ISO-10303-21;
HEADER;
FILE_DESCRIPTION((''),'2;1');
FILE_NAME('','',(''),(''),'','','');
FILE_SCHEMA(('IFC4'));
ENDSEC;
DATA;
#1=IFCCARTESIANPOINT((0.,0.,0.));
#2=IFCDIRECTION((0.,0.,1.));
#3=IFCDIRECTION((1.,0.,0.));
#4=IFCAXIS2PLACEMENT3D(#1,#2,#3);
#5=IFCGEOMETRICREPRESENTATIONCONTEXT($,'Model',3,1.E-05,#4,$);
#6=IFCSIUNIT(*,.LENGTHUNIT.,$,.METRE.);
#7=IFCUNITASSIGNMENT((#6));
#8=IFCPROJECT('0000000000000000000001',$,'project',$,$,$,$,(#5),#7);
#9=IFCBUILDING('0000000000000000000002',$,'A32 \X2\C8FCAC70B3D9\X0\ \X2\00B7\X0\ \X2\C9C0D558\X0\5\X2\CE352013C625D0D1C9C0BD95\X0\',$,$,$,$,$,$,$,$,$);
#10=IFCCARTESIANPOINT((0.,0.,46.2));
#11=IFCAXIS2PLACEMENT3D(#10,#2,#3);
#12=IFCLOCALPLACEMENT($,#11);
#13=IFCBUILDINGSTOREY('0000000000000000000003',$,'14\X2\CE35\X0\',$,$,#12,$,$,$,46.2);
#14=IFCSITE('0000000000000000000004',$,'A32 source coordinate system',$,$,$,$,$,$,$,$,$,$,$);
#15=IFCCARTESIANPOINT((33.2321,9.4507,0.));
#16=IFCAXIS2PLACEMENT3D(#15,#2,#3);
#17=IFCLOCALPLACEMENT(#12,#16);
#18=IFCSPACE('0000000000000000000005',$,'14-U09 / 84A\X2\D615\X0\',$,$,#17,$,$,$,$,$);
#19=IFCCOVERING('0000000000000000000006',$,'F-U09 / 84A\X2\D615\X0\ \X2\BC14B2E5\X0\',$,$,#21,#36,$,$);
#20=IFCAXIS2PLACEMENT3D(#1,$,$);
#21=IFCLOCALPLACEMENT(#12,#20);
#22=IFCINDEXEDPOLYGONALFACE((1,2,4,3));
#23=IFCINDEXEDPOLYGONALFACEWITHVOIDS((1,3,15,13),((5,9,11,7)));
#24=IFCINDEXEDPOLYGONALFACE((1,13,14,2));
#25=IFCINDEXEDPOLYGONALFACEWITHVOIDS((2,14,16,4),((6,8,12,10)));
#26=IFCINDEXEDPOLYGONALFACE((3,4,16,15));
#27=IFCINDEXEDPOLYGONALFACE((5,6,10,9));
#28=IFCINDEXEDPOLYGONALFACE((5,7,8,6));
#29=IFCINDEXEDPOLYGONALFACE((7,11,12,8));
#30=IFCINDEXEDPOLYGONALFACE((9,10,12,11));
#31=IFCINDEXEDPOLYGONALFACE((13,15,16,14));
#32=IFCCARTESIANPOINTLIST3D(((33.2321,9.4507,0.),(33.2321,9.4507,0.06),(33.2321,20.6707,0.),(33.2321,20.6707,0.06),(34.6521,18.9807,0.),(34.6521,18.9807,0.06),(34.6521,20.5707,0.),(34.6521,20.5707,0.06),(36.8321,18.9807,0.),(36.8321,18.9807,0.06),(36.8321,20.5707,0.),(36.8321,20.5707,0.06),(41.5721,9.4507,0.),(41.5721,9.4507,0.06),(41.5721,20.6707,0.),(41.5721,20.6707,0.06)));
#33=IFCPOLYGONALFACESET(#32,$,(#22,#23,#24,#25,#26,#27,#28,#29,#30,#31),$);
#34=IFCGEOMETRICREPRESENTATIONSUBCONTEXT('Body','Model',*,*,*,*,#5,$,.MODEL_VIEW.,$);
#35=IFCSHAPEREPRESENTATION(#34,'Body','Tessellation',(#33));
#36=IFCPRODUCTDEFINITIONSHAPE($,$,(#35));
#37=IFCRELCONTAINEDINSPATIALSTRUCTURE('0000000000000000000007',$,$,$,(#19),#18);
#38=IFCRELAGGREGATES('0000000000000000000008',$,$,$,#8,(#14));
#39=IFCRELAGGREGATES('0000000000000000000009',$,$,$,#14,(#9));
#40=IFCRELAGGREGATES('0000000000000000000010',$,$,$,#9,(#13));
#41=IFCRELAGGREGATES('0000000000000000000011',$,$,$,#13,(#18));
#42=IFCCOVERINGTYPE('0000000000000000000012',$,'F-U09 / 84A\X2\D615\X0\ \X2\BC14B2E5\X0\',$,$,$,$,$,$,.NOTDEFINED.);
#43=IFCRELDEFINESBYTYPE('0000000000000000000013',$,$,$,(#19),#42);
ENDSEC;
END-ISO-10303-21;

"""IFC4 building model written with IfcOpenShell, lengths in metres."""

from ifc_helpers import new_model, si_unit, frame, origin, origin_with_axes, place, context, subcontext, project, spatial, polyline, outline, extrude, source, transform, mapped, type_object, type_shapes, element, save


model = new_model("IFC4")

# Units and contexts
model_context = context("Model", 3, precision=1e-05, world=origin_with_axes())
body_context = subcontext(model_context, "Body", "Model", "MODEL_VIEW")
ifc_project = project(units=[si_unit("LENGTHUNIT", "METRE")], contexts=[model_context])

# Site, building, storey, space
storey_placement = place(None, frame((0.0, 0.0, 46.2), z_axis=(0.0, 0.0, 1.0), x_axis=(1.0, 0.0, 0.0)))
space_placement = place(storey_placement, frame((33.2321, 9.4507, 0.0), z_axis=(0.0, 0.0, 1.0), x_axis=(1.0, 0.0, 0.0)))
site = spatial("IfcSite", under=ifc_project, Name="A32 source coordinate system")
building = spatial("IfcBuilding", under=site, Name="A32 주거동 · 지하5층–옥탑지붕")
storey = spatial("IfcBuildingStorey", under=building, at=storey_placement, Name="14층", Elevation=46.2)
space = spatial("IfcSpace", under=storey, at=space_placement, Name="14-U09 / 84A형")

# Covering
covering_type_1 = type_object("IfcCoveringType", Name="F-U09 / 84A형 바닥", PredefinedType="NOTDEFINED")
shared_shape_1 = source(origin(), body_context, "Body", "SweptSolid", [
    extrude(outline(polyline([(0.0, 0.0), (0.0, 11.22), (8.34, 11.22), (8.34, 0.0), (0.0, 0.0)]), holes=[polyline([(1.42, 11.12), (1.42, 9.53), (3.6, 9.53), (3.6, 11.12), (1.42, 11.12)])]), origin(), (0.0, 0.0, 1.0), 0.06),
])
type_shapes(covering_type_1, [shared_shape_1])
covering_1_placement = place(space_placement, origin_with_axes())
element("IfcCovering", 1, at=covering_1_placement, inside=space, type_object=covering_type_1, Name="F-U09 / 84A형 바닥", context=body_context, shape_type="MappedRepresentation", body=[
    mapped(shared_shape_1, transform((0.0, 0.0, 0.0), scale=1.0)),
])

save(model, "model.ifc")
